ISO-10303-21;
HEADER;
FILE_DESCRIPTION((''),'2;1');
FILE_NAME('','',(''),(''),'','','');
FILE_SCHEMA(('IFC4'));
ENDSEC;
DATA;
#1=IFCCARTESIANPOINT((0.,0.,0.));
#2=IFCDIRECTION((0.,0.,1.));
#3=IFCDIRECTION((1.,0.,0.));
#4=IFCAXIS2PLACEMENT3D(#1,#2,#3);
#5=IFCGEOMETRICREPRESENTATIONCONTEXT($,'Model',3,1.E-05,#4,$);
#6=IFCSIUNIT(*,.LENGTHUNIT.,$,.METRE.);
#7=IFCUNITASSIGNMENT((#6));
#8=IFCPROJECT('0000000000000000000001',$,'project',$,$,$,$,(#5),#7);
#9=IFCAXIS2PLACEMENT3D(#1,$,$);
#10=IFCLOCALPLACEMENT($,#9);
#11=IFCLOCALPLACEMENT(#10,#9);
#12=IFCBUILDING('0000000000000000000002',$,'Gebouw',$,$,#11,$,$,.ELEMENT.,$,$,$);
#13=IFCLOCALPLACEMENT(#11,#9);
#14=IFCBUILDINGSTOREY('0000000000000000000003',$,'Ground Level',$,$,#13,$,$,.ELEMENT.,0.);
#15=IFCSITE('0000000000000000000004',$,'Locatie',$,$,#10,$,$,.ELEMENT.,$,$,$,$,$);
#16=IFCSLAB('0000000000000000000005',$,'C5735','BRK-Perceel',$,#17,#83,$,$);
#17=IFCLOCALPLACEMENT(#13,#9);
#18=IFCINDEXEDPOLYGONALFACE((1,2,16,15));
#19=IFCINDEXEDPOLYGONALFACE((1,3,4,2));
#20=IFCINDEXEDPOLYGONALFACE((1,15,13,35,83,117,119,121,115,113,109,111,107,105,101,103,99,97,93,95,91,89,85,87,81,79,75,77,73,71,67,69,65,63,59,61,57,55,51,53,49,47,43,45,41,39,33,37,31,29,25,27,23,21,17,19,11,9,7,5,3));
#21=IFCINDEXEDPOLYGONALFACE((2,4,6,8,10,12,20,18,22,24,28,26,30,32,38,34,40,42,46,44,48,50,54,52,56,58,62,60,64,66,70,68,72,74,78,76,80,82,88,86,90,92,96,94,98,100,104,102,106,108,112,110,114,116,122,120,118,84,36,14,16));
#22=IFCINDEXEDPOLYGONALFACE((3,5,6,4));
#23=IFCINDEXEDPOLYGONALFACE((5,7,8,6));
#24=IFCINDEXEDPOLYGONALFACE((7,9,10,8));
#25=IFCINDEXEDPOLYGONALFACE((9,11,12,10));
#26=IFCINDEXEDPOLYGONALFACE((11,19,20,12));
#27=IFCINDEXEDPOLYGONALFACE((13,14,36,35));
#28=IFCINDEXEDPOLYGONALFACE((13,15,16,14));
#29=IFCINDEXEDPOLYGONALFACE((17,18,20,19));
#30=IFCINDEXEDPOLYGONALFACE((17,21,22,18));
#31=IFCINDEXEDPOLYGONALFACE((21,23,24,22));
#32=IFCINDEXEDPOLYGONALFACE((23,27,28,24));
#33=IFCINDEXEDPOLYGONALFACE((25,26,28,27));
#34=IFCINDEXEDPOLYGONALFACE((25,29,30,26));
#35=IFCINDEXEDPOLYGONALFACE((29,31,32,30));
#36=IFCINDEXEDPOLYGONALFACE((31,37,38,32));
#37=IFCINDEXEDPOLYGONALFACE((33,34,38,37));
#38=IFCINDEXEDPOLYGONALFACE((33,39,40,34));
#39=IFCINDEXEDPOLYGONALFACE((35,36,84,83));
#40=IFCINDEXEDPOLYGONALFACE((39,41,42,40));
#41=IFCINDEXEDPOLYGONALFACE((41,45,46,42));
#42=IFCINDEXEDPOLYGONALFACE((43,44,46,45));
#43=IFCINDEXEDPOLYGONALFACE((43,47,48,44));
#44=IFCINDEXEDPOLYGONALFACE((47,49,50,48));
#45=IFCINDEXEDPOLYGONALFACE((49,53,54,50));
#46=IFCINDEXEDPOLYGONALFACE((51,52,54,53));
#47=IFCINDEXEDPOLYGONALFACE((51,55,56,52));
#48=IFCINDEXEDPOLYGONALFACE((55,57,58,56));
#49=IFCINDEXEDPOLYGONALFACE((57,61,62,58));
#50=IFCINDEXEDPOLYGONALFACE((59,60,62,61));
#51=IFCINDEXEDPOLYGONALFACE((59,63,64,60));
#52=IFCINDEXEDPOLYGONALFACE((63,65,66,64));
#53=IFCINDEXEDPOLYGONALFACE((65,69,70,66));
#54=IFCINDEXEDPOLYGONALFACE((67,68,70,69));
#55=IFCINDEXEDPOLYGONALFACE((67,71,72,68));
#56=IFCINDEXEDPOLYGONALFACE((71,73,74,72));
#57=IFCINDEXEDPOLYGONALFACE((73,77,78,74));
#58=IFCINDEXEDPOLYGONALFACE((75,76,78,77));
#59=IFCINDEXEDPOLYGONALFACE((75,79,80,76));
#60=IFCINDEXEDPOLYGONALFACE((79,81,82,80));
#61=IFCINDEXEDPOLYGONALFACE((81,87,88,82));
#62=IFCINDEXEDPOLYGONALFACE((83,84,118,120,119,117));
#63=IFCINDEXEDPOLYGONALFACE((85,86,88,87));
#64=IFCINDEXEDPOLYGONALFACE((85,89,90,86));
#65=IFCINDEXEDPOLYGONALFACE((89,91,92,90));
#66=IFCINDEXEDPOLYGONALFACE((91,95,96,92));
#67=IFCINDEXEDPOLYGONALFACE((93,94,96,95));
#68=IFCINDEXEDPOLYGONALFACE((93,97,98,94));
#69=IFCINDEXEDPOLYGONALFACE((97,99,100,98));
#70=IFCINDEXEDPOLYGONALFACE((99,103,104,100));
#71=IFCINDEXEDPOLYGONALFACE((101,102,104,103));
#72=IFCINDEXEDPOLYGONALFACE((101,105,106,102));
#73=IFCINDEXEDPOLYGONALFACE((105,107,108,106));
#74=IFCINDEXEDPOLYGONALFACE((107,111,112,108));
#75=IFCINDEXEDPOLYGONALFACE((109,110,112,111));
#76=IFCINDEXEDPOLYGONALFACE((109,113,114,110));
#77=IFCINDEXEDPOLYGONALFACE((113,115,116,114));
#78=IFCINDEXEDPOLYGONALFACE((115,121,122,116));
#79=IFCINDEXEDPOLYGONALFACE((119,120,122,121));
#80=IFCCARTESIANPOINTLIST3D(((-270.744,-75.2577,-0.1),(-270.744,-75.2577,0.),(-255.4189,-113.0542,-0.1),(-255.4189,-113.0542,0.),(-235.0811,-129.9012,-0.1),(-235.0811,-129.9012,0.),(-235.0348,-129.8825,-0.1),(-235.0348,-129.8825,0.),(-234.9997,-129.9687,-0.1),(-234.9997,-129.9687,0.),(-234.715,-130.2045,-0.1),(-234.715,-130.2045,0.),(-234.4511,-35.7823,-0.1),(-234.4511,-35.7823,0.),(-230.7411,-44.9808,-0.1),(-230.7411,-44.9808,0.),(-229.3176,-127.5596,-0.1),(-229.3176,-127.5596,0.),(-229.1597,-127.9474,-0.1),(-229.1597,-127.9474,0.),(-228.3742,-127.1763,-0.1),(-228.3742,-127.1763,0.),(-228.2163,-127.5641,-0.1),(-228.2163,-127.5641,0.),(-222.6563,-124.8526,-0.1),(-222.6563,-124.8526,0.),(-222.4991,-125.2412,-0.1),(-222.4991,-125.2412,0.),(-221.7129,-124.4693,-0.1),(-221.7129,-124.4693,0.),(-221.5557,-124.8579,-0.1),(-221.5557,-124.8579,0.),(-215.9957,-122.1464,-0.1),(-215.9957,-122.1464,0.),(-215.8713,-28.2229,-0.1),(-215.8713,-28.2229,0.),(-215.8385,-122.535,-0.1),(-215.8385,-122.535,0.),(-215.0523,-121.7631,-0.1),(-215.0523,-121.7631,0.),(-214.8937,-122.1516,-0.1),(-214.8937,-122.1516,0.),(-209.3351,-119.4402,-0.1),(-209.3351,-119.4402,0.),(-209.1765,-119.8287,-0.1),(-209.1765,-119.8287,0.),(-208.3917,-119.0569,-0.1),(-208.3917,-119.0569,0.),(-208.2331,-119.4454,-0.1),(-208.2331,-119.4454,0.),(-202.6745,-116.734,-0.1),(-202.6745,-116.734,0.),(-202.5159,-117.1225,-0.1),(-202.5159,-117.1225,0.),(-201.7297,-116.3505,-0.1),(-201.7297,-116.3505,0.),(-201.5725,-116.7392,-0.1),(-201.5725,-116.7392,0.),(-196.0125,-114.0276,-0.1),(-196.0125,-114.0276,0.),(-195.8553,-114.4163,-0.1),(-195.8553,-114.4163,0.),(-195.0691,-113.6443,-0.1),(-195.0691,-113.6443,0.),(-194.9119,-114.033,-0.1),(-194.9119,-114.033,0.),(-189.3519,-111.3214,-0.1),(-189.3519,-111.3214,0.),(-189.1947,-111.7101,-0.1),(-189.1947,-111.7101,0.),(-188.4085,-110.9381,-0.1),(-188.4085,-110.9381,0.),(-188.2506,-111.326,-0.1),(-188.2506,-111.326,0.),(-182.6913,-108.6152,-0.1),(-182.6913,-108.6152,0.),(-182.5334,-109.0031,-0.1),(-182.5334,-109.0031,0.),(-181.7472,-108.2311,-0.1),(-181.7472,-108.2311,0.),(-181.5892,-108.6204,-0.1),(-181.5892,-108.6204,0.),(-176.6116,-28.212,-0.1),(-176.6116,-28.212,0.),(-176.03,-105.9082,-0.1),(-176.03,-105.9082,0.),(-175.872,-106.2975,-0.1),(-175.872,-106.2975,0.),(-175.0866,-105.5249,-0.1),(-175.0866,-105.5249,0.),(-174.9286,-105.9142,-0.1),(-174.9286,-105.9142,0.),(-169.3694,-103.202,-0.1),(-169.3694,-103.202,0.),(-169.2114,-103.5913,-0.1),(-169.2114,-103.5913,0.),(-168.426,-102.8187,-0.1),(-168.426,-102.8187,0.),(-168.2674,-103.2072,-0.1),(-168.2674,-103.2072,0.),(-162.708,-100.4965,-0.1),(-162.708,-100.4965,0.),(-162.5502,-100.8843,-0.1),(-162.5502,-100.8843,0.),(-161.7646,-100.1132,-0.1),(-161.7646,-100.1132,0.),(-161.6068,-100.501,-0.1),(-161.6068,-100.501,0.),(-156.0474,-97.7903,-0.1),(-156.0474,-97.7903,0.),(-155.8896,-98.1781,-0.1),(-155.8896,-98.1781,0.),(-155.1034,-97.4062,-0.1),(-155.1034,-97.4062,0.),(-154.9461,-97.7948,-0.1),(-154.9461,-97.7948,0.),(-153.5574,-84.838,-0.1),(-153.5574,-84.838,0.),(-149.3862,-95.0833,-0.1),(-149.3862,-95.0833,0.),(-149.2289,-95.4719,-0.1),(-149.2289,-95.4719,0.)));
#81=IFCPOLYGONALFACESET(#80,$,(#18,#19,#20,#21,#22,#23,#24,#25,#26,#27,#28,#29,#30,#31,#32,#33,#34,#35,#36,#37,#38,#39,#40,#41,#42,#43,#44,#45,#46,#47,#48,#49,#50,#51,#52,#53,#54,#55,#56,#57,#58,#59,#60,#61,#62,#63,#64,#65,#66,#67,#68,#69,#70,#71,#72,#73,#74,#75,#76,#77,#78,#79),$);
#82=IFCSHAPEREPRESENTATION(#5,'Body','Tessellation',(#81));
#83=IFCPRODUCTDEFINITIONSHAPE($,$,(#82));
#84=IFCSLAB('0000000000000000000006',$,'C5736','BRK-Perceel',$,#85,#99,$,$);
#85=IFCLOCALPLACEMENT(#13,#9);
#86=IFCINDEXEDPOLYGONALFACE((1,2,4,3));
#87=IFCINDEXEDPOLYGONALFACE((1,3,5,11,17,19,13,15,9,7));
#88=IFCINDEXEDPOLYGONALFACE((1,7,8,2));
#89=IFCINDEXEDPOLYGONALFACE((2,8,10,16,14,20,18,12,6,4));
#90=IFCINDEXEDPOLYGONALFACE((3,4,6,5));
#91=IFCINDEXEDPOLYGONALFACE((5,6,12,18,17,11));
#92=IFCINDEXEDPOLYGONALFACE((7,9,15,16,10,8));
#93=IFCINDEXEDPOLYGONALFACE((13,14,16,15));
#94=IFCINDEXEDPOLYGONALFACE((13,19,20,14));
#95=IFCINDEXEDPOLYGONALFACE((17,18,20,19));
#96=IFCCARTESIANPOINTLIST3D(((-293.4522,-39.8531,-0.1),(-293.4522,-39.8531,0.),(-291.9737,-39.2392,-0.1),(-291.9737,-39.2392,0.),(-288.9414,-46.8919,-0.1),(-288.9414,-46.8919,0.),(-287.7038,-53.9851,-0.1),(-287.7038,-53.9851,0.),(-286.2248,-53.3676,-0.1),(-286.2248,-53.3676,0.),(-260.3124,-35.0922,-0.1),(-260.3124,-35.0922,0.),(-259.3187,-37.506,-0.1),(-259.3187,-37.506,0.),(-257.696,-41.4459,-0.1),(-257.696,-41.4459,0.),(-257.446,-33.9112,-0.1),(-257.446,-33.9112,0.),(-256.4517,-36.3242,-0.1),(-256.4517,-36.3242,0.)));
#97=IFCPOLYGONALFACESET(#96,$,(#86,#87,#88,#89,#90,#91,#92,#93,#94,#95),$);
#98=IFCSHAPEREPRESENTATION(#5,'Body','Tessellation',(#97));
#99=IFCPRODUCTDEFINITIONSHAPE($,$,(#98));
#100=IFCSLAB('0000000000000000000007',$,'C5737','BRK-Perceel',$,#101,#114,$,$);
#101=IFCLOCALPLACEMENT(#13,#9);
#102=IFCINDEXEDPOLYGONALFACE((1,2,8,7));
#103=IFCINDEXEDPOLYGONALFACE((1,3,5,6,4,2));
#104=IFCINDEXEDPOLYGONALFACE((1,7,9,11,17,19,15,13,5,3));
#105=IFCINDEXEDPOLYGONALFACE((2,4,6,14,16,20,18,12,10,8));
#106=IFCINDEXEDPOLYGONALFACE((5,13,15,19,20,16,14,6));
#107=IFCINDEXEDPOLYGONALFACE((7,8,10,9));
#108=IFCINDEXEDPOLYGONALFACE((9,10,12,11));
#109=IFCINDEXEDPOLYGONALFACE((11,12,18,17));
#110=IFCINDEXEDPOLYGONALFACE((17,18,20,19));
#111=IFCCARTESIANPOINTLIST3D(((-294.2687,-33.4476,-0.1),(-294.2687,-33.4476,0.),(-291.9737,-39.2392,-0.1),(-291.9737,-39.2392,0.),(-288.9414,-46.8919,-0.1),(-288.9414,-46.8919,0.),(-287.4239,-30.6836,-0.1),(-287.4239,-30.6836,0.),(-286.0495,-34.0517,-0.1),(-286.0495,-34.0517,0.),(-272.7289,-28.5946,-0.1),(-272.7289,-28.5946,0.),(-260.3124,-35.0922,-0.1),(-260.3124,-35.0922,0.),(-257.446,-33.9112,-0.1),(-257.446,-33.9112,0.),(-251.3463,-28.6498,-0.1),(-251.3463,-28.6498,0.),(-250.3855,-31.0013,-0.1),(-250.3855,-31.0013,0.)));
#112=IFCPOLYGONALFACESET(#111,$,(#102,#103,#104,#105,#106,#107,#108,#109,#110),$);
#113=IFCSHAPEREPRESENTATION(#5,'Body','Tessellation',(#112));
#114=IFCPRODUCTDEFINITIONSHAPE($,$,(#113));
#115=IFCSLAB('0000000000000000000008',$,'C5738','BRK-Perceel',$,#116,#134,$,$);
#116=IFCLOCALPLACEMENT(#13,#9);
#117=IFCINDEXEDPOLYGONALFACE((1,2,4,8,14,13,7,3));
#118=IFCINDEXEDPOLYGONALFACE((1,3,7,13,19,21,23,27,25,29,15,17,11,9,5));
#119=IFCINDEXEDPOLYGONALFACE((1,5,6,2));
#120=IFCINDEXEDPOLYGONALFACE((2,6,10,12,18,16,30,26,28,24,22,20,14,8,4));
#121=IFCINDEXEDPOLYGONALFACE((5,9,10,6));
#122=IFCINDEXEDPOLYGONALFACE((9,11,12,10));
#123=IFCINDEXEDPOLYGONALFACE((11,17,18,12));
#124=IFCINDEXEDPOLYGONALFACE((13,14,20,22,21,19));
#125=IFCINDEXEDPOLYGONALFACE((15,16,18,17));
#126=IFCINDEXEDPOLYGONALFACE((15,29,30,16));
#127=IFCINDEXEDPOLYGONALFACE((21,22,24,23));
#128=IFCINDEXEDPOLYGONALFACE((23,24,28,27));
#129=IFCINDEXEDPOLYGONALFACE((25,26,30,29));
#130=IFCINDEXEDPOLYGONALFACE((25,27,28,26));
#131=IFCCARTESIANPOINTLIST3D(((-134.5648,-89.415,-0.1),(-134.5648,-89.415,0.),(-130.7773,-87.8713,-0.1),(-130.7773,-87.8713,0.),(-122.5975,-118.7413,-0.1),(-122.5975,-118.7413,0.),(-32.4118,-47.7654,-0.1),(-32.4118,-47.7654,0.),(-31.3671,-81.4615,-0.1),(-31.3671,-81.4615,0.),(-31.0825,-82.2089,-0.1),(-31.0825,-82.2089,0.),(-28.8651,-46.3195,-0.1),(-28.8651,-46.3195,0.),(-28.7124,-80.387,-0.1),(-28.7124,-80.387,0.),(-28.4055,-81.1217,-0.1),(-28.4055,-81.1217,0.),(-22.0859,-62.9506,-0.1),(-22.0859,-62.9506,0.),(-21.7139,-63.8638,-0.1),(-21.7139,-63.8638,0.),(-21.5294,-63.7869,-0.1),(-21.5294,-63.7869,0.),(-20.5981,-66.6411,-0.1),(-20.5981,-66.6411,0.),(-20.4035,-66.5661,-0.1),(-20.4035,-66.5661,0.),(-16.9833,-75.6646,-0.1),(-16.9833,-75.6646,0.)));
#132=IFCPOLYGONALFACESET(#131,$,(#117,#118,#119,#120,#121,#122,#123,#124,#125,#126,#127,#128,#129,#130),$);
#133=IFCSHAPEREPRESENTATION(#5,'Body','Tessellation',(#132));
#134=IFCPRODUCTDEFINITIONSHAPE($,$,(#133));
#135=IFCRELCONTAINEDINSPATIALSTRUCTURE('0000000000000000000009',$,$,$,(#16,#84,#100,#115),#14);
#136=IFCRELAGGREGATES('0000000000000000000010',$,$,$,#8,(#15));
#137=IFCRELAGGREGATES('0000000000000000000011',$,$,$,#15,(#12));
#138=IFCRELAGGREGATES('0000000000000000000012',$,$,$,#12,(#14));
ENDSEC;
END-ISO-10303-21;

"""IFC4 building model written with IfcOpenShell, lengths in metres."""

from ifc_helpers import new_model, si_unit, frame, origin, origin_with_axes, place, context, project, spatial, polyline, outline, extrude, element, save


model = new_model("IFC4")

# Units and contexts
model_context = context("Model", 3, precision=1e-05, world=origin_with_axes())
ifc_project = project(units=[si_unit("LENGTHUNIT", "METRE")], contexts=[model_context])

# Site, building, storey
site_placement = place(None, origin())
site = spatial("IfcSite", under=ifc_project, at=site_placement, Name="Locatie", CompositionType="ELEMENT")
building_placement = place(site_placement, origin())
building = spatial("IfcBuilding", under=site, at=building_placement, Name="Gebouw", CompositionType="ELEMENT")
storey_placement = place(building_placement, origin())
storey = spatial("IfcBuildingStorey", under=building, at=storey_placement, Name="Ground Level", CompositionType="ELEMENT", Elevation=0.0)

# Slabs
slab_1_placement = place(storey_placement, origin())
element("IfcSlab", 1, at=slab_1_placement, inside=storey, Name="C5735", Description="BRK-Perceel", context=model_context, shape_type="SweptSolid", body=[
    extrude(outline(polyline([(-270.744, -75.2577), (-230.7411, -44.9808), (-234.4511, -35.7823), (-215.8713, -28.2229), (-176.6116, -28.212), (-153.5574, -84.838), (-149.3862, -95.0833), (-149.2289, -95.4719), (-154.9461, -97.7948), (-155.1034, -97.4062), (-156.0474, -97.7903), (-155.8896, -98.1781), (-161.6068, -100.501), (-161.7646, -100.1132), (-162.708, -100.4965), (-162.5502, -100.8843), (-168.2674, -103.2072), (-168.426, -102.8187), (-169.3694, -103.202), (-169.2114, -103.5913), (-174.9286, -105.9142), (-175.0866, -105.5249), (-176.03, -105.9082), (-175.872, -106.2975), (-181.5892, -108.6204), (-181.7472, -108.2311), (-182.6913, -108.6152), (-182.5334, -109.0031), (-188.2506, -111.326), (-188.4085, -110.9381), (-189.3519, -111.3214), (-189.1947, -111.7101), (-194.9119, -114.033), (-195.0691, -113.6443), (-196.0125, -114.0276), (-195.8553, -114.4163), (-201.5725, -116.7392), (-201.7297, -116.3505), (-202.6745, -116.734), (-202.5159, -117.1225), (-208.2331, -119.4454), (-208.3917, -119.0569), (-209.3351, -119.4402), (-209.1765, -119.8287), (-214.8937, -122.1516), (-215.0523, -121.7631), (-215.9957, -122.1464), (-215.8385, -122.535), (-221.5557, -124.8579), (-221.7129, -124.4693), (-222.6563, -124.8526), (-222.4991, -125.2412), (-228.2163, -127.5641), (-228.3742, -127.1763), (-229.3176, -127.5596), (-229.1597, -127.9474), (-234.715, -130.2045), (-234.9997, -129.9687), (-235.0348, -129.8825), (-235.0811, -129.9012), (-255.4189, -113.0542), (-270.744, -75.2577)])), frame((0.0, 0.0, -0.1), z_axis=(0.0, 0.0, 1.0), x_axis=(1.0, 0.0, 0.0)), (0.0, 0.0, 1.0), 0.1),
])
slab_2_placement = place(storey_placement, origin())
element("IfcSlab", 2, at=slab_2_placement, inside=storey, Name="C5736", Description="BRK-Perceel", context=model_context, shape_type="SweptSolid", body=[
    extrude(outline(polyline([(-256.4517, -36.3242), (-259.3187, -37.506), (-257.696, -41.4459), (-286.2248, -53.3676), (-287.7038, -53.9851), (-293.4522, -39.8531), (-291.9737, -39.2392), (-288.9414, -46.8919), (-260.3124, -35.0922), (-257.446, -33.9112), (-256.4517, -36.3242)])), frame((0.0, 0.0, -0.1), z_axis=(0.0, 0.0, 1.0), x_axis=(1.0, 0.0, 0.0)), (0.0, 0.0, 1.0), 0.1),
])
slab_3_placement = place(storey_placement, origin())
element("IfcSlab", 3, at=slab_3_placement, inside=storey, Name="C5737", Description="BRK-Perceel", context=model_context, shape_type="SweptSolid", body=[
    extrude(outline(polyline([(-294.2687, -33.4476), (-287.4239, -30.6836), (-286.0495, -34.0517), (-272.7289, -28.5946), (-251.3463, -28.6498), (-250.3855, -31.0013), (-257.446, -33.9112), (-260.3124, -35.0922), (-288.9414, -46.8919), (-291.9737, -39.2392), (-294.2687, -33.4476)])), frame((0.0, 0.0, -0.1), z_axis=(0.0, 0.0, 1.0), x_axis=(1.0, 0.0, 0.0)), (0.0, 0.0, 1.0), 0.1),
])
slab_4_placement = place(storey_placement, origin())
element("IfcSlab", 4, at=slab_4_placement, inside=storey, Name="C5738", Description="BRK-Perceel", context=model_context, shape_type="SweptSolid", body=[
    extrude(outline(polyline([(-22.0859, -62.9506), (-21.7139, -63.8638), (-21.5294, -63.7869), (-20.4035, -66.5661), (-20.5981, -66.6411), (-16.9833, -75.6646), (-28.7124, -80.387), (-28.4055, -81.1217), (-31.0825, -82.2089), (-31.3671, -81.4615), (-122.5975, -118.7413), (-134.5648, -89.415), (-130.7773, -87.8713), (-32.4118, -47.7654), (-28.8651, -46.3195), (-22.0859, -62.9506)])), frame((0.0, 0.0, -0.1), z_axis=(0.0, 0.0, 1.0), x_axis=(1.0, 0.0, 0.0)), (0.0, 0.0, 1.0), 0.1),
])

save(model, "model.ifc")
